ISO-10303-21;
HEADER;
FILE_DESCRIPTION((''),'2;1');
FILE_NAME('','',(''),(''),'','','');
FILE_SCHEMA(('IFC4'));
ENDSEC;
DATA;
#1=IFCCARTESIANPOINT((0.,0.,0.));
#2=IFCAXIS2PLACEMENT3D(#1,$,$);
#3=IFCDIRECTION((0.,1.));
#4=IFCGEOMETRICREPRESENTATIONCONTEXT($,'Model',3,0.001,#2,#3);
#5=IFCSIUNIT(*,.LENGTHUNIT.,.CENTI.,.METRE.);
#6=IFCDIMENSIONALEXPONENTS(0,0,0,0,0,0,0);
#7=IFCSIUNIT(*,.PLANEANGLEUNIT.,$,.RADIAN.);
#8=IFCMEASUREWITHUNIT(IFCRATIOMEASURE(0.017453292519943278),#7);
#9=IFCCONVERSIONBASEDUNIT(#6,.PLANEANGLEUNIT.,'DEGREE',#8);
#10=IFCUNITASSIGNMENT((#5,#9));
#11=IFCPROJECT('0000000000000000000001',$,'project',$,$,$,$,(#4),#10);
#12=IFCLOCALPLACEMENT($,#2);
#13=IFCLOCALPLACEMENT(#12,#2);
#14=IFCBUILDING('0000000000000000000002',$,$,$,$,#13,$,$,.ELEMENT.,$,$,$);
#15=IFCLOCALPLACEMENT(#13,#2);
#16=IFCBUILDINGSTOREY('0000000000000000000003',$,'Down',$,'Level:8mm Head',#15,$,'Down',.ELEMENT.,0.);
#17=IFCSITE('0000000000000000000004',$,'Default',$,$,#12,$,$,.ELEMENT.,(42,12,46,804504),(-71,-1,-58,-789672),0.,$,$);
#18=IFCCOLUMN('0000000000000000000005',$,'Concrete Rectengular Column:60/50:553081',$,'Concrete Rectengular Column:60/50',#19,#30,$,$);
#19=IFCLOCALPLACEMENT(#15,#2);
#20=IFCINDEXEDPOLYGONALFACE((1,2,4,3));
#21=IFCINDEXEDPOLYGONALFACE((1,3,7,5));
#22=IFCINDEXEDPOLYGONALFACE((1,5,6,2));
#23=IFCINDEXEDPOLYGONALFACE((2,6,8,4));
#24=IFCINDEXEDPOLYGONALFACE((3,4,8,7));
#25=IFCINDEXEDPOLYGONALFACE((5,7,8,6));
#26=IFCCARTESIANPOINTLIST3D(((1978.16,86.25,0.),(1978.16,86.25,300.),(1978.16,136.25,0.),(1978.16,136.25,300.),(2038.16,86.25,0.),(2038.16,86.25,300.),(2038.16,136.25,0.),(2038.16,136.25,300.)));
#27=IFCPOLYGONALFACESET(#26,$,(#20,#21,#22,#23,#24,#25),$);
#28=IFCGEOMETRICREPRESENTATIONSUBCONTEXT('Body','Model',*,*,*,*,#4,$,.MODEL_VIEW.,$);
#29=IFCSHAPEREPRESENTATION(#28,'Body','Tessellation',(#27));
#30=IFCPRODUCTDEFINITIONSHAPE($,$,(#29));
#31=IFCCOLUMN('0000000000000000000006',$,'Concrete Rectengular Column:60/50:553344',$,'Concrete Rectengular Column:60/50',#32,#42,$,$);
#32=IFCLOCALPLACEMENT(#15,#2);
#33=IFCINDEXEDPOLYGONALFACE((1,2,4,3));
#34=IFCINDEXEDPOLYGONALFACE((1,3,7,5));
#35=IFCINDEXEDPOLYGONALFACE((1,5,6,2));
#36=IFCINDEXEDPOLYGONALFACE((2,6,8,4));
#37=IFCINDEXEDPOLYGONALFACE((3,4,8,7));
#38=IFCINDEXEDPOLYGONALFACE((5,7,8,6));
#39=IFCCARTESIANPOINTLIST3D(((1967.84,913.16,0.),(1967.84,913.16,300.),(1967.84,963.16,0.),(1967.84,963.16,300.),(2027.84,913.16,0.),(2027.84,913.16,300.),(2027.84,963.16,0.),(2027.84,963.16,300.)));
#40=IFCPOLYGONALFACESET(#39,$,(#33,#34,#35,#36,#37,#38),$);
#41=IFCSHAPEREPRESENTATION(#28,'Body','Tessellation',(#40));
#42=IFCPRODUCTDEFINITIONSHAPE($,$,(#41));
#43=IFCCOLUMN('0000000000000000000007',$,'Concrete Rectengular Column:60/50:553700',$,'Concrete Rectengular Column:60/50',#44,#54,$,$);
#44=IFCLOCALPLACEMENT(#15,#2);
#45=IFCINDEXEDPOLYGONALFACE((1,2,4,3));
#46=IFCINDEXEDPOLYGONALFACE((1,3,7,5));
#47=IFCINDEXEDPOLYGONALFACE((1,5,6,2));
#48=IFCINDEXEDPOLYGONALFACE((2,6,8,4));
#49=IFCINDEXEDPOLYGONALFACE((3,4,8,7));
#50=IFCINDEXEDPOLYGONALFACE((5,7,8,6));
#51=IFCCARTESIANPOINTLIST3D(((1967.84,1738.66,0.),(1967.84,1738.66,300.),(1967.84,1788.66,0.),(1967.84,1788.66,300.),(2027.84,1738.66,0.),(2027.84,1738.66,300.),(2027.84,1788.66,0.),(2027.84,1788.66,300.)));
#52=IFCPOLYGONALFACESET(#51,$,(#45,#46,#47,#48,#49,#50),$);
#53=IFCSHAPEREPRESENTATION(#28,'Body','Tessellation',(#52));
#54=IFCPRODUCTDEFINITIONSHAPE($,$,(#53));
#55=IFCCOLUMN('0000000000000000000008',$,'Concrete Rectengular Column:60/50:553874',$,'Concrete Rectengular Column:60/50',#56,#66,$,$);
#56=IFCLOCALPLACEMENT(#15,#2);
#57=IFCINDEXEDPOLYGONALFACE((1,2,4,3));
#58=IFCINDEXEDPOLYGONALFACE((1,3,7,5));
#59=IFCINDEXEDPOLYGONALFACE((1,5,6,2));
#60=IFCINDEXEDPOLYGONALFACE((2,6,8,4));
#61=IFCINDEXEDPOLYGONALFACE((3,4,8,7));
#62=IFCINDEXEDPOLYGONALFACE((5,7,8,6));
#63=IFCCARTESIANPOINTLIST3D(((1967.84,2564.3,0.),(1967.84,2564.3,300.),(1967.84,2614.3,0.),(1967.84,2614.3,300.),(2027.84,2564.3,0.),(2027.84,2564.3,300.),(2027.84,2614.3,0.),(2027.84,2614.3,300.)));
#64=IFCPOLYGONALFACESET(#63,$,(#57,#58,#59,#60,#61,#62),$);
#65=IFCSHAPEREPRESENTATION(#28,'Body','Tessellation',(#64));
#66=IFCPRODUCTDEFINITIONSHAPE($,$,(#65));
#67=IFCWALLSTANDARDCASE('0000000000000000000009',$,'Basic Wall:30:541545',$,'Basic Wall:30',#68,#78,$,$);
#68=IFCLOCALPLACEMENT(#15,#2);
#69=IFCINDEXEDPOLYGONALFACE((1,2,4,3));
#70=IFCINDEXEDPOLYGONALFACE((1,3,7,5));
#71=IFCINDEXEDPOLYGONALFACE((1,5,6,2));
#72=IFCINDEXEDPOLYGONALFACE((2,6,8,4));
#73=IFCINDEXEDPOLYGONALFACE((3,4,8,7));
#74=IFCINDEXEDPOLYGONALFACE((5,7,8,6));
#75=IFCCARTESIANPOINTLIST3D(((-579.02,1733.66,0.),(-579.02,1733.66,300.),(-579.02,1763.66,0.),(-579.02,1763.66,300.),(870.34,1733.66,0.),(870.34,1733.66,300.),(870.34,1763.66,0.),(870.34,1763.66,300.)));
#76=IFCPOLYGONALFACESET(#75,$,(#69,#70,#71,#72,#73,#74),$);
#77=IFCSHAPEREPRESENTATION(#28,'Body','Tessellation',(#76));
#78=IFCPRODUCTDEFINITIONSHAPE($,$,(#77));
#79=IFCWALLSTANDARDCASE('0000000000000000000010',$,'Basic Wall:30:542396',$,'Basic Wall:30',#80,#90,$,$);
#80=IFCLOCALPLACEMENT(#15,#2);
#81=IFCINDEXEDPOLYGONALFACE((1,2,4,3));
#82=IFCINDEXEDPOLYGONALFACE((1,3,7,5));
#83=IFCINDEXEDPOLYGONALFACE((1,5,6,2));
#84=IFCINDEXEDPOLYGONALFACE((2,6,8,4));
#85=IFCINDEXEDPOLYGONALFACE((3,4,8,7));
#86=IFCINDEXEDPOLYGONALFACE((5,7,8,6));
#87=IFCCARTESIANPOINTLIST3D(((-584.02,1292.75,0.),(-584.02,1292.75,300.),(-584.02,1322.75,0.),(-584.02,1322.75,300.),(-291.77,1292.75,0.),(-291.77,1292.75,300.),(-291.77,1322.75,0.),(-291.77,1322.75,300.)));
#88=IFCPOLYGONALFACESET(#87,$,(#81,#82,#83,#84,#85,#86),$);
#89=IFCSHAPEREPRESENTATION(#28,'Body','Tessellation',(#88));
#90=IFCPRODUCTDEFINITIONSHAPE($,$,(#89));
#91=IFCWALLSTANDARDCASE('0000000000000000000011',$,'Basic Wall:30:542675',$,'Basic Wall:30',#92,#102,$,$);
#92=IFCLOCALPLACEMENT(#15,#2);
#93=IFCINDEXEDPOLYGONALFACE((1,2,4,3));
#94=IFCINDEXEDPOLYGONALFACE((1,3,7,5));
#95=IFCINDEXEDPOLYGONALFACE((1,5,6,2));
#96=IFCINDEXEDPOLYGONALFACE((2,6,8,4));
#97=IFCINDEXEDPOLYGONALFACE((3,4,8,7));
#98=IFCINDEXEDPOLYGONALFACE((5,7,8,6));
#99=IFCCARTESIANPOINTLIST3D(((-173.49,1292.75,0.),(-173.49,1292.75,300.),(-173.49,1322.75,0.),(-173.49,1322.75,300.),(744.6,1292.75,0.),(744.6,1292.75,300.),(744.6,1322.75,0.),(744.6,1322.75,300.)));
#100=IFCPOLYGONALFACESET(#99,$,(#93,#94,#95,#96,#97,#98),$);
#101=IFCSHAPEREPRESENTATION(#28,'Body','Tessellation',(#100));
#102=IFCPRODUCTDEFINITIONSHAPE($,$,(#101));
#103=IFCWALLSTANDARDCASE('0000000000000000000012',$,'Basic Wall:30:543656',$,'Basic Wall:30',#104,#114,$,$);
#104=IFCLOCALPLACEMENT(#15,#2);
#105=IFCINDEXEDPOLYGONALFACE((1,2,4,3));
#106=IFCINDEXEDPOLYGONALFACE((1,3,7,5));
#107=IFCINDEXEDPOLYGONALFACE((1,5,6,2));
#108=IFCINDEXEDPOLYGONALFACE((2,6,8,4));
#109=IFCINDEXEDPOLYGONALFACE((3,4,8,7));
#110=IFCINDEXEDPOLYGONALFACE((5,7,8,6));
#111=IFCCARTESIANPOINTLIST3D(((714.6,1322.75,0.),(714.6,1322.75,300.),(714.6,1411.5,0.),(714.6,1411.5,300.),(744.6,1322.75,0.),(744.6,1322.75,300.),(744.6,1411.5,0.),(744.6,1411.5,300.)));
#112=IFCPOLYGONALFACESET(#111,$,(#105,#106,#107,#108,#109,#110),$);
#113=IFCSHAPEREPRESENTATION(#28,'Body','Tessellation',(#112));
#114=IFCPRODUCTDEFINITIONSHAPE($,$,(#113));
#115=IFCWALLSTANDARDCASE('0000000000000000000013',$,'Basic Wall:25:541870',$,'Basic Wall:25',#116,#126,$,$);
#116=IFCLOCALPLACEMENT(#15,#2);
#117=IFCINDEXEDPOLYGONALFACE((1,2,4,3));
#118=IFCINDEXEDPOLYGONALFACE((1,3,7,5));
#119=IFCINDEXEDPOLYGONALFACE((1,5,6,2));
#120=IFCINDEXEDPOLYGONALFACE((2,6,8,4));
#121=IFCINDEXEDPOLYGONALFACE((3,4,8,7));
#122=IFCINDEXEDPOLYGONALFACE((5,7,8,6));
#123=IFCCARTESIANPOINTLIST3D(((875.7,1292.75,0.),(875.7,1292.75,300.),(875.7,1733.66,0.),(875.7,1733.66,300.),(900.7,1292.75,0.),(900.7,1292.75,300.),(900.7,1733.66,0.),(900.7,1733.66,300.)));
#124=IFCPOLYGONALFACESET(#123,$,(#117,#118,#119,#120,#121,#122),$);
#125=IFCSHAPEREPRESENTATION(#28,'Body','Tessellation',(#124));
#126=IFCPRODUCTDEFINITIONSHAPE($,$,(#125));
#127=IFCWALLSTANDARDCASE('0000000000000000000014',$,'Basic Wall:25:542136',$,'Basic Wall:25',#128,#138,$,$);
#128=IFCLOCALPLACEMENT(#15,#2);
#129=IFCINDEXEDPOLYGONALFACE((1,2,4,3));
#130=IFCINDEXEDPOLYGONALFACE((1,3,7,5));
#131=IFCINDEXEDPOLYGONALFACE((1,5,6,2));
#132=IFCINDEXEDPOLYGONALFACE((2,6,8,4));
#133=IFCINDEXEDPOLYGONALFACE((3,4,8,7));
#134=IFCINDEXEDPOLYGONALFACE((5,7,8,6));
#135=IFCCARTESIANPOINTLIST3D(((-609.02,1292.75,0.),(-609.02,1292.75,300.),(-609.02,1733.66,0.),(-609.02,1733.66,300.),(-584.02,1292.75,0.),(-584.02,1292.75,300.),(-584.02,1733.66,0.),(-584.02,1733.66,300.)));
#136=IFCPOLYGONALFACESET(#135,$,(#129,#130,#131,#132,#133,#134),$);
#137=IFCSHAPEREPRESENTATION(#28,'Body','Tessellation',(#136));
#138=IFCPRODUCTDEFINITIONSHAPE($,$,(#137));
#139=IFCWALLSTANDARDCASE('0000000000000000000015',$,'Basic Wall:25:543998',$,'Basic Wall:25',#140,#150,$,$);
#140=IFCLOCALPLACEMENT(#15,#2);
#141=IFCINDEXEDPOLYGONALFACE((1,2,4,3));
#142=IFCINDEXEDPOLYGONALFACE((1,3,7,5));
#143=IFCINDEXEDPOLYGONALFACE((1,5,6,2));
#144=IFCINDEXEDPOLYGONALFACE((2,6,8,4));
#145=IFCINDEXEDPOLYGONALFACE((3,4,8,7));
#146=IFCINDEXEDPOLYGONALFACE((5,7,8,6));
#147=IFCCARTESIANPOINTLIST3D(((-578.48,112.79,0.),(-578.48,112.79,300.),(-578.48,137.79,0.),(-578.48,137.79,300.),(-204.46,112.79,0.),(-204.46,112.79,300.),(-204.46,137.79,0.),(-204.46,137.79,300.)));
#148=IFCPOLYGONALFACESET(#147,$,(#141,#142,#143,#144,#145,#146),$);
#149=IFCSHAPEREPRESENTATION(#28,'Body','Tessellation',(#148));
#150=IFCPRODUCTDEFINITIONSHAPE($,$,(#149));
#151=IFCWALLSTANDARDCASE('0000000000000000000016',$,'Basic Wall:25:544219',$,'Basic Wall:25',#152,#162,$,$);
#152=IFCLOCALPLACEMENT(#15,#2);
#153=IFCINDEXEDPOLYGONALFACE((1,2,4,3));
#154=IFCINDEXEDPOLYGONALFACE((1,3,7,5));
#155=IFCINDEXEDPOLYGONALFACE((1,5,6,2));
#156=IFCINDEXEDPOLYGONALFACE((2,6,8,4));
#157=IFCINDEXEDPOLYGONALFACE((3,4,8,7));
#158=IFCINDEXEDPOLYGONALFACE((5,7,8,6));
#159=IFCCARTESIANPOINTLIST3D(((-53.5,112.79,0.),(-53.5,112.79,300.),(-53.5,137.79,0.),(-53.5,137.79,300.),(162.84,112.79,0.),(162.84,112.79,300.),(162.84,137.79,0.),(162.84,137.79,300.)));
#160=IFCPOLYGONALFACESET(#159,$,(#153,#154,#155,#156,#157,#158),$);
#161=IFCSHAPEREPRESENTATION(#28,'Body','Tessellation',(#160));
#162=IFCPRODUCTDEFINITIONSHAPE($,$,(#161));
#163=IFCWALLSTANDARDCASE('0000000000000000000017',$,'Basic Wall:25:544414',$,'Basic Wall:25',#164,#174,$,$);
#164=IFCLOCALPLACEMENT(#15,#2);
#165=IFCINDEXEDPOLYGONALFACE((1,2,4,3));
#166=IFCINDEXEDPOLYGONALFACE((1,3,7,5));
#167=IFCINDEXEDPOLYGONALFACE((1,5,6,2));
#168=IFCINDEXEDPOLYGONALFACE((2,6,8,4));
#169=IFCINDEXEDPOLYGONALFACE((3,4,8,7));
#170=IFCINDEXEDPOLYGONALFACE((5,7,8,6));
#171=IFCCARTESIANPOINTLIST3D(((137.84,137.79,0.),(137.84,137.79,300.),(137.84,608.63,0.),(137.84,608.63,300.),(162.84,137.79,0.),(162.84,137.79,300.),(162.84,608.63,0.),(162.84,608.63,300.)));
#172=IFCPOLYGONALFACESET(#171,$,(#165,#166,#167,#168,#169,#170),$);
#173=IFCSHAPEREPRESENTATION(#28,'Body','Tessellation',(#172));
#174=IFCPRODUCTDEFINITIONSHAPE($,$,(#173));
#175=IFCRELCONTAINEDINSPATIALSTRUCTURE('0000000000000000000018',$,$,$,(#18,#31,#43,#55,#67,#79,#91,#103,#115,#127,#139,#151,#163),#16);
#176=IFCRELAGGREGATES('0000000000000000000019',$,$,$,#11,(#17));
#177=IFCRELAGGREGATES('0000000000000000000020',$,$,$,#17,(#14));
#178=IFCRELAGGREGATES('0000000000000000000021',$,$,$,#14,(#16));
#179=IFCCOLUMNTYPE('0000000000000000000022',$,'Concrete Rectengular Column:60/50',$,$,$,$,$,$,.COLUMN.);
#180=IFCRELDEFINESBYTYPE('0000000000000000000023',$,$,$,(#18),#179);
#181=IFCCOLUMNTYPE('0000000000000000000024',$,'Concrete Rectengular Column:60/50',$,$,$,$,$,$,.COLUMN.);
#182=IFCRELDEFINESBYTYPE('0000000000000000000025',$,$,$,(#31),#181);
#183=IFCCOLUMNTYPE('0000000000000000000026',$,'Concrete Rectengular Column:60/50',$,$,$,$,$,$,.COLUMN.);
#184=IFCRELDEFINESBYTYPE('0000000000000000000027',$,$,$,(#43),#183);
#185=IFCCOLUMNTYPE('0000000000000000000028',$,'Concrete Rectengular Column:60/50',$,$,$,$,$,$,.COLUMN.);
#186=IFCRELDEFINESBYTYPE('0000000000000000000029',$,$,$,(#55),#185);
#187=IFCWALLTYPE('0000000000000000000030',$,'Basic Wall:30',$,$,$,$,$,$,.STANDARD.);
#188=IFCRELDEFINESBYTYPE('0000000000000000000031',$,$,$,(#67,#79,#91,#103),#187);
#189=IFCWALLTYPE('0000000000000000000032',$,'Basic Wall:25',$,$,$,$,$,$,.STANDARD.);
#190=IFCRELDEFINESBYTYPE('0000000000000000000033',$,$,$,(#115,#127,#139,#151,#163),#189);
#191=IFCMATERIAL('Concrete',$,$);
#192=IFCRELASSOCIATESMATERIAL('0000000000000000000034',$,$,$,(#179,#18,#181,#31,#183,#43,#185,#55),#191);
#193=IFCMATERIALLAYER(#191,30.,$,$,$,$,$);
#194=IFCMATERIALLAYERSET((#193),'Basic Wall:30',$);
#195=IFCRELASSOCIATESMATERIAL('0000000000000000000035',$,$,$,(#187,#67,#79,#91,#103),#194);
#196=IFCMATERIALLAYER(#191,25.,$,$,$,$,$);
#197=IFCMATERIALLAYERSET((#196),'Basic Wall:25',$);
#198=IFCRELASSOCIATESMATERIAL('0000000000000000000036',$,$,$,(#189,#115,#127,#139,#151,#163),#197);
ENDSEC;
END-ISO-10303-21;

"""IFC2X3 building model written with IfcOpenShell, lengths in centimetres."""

from ifc_helpers import new_model, entity, si_unit, converted_unit, direction, frame, frame_2d, origin, origin_2d_with_axis, place, context, subcontext, project, spatial, rectangle, extrude, source, transform, mapped, material, layer, layer_set, layer_usage, type_object, type_shapes, element, save


model = new_model("IFC2X3")

# Units and contexts
model_context = context("Model", 3, precision=0.001, world=origin(), true_north=direction((0.0, 1.0)))
body_context = subcontext(model_context, "Body", "Model", "MODEL_VIEW")
ifc_project = project(units=[si_unit("LENGTHUNIT", "METRE", prefix="CENTI"), converted_unit("PLANEANGLEUNIT", "DEGREE", entity("IfcRatioMeasure", 0.017453292519943278), si_unit("PLANEANGLEUNIT", "RADIAN"), dimensions=[0, 0, 0, 0, 0, 0, 0])], contexts=[model_context])

# Site, building, storey
site_placement = place(None, origin())
site = spatial("IfcSite", under=ifc_project, at=site_placement, Name="Default", CompositionType="ELEMENT", RefLatitude=(42, 12, 46, 804504), RefLongitude=(-71, -1, -58, -789672), RefElevation=0.0)
building_placement = place(site_placement, origin())
building = spatial("IfcBuilding", under=site, at=building_placement, CompositionType="ELEMENT")
storey_placement = place(building_placement, origin())
storey = spatial("IfcBuildingStorey", under=building, at=storey_placement, Name="Down", ObjectType="Level:8mm Head", LongName="Down", CompositionType="ELEMENT", Elevation=0.0)

# Columns
ifc_material = material(Name="Concrete")
column_type_1 = type_object("IfcColumnType", Name="Concrete Rectengular Column:60/50", PredefinedType="COLUMN", material=ifc_material)
shared_shape_1 = source(origin(), body_context, "Body", "SweptSolid", [
    extrude(rectangle(XDim=50.0, YDim=60.0, at=origin_2d_with_axis()), frame((2008.16, 111.25, 0.0), z_axis=(0.0, 0.0, 1.0), x_axis=(0.0, -1.0, 0.0)), (0.0, 0.0, 1.0), 300.0),
])
type_shapes(column_type_1, [shared_shape_1])
column_1_placement = place(storey_placement, origin())
element("IfcColumn", 1, at=column_1_placement, inside=storey, type_object=column_type_1, material=ifc_material, Name="Concrete Rectengular Column:60/50:553081", ObjectType="Concrete Rectengular Column:60/50", context=body_context, shape_type="MappedRepresentation", body=[
    mapped(shared_shape_1, transform((0.0, 0.0, 0.0), scale=1.0)),
])
column_type_2 = type_object("IfcColumnType", Name="Concrete Rectengular Column:60/50", PredefinedType="COLUMN", material=ifc_material)
shared_shape_2 = source(origin(), body_context, "Body", "SweptSolid", [
    extrude(rectangle(XDim=50.0, YDim=60.0, at=frame_2d((0.0, 0.0), x_axis=(1.0, 0.0))), frame((1997.84, 938.16, 0.0), z_axis=(0.0, 0.0, 1.0), x_axis=(0.0, -1.0, 0.0)), (0.0, 0.0, 1.0), 300.0),
])
type_shapes(column_type_2, [shared_shape_2])
column_2_placement = place(storey_placement, origin())
element("IfcColumn", 2, at=column_2_placement, inside=storey, type_object=column_type_2, material=ifc_material, Name="Concrete Rectengular Column:60/50:553344", ObjectType="Concrete Rectengular Column:60/50", context=body_context, shape_type="MappedRepresentation", body=[
    mapped(shared_shape_2, transform((0.0, 0.0, 0.0), scale=1.0)),
])
column_type_3 = type_object("IfcColumnType", Name="Concrete Rectengular Column:60/50", PredefinedType="COLUMN", material=ifc_material)
shared_shape_3 = source(origin(), body_context, "Body", "SweptSolid", [
    extrude(rectangle(XDim=50.0, YDim=60.0, at=origin_2d_with_axis()), frame((1997.84, 1763.66, 0.0), z_axis=(0.0, 0.0, 1.0), x_axis=(0.0, -1.0, 0.0)), (0.0, 0.0, 1.0), 300.0),
])
type_shapes(column_type_3, [shared_shape_3])
column_3_placement = place(storey_placement, origin())
element("IfcColumn", 3, at=column_3_placement, inside=storey, type_object=column_type_3, material=ifc_material, Name="Concrete Rectengular Column:60/50:553700", ObjectType="Concrete Rectengular Column:60/50", context=body_context, shape_type="MappedRepresentation", body=[
    mapped(shared_shape_3, transform((0.0, 0.0, 0.0), scale=1.0)),
])
column_type_4 = type_object("IfcColumnType", Name="Concrete Rectengular Column:60/50", PredefinedType="COLUMN", material=ifc_material)
shared_shape_4 = source(origin(), body_context, "Body", "SweptSolid", [
    extrude(rectangle(XDim=50.0, YDim=60.0, at=origin_2d_with_axis()), frame((1997.84, 2589.3, 0.0), z_axis=(0.0, 0.0, 1.0), x_axis=(0.0, -1.0, 0.0)), (0.0, 0.0, 1.0), 300.0),
])
type_shapes(column_type_4, [shared_shape_4])
column_4_placement = place(storey_placement, origin())
element("IfcColumn", 4, at=column_4_placement, inside=storey, type_object=column_type_4, material=ifc_material, Name="Concrete Rectengular Column:60/50:553874", ObjectType="Concrete Rectengular Column:60/50", context=body_context, shape_type="MappedRepresentation", body=[
    mapped(shared_shape_4, transform((0.0, 0.0, 0.0), scale=1.0)),
])

# Walls
ifc_layer_1 = layer(ifc_material, 30.0)
ifc_layer_set_1 = layer_set([ifc_layer_1], Name="Basic Wall:30")
ifc_layer_usage_1 = layer_usage(ifc_layer_set_1, "AXIS2", "POSITIVE", -15.0)
wall_type_1 = type_object("IfcWallType", Name="Basic Wall:30", PredefinedType="STANDARD", material=ifc_layer_set_1)
wall_1_placement = place(storey_placement, frame((-579.02, 1748.66, 0.0)))
element("IfcWallStandardCase", 5, at=wall_1_placement, inside=storey, type_object=wall_type_1, material=ifc_layer_usage_1, Name="Basic Wall:30:541545", ObjectType="Basic Wall:30", context=body_context, shape_type="SweptSolid", body=[
    extrude(rectangle(XDim=1449.35, YDim=30.0, at=frame_2d((724.68, 0.0), x_axis=(-1.0, 0.0))), origin(), (0.0, 0.0, 1.0), 300.0),
])
ifc_layer_usage_2 = layer_usage(ifc_layer_set_1, "AXIS2", "POSITIVE", -15.0)
wall_2_placement = place(storey_placement, frame((-584.02, 1307.75, 0.0)))
element("IfcWallStandardCase", 6, at=wall_2_placement, inside=storey, type_object=wall_type_1, material=ifc_layer_usage_2, Name="Basic Wall:30:542396", ObjectType="Basic Wall:30", context=body_context, shape_type="SweptSolid", body=[
    extrude(rectangle(XDim=292.24, YDim=30.0, at=frame_2d((146.12, 0.0), x_axis=(-1.0, 0.0))), origin(), (0.0, 0.0, 1.0), 300.0),
])
ifc_layer_usage_3 = layer_usage(ifc_layer_set_1, "AXIS2", "POSITIVE", -15.0)
wall_3_placement = place(storey_placement, frame((-173.49, 1307.75, 0.0)))
element("IfcWallStandardCase", 7, at=wall_3_placement, inside=storey, type_object=wall_type_1, material=ifc_layer_usage_3, Name="Basic Wall:30:542675", ObjectType="Basic Wall:30", context=body_context, shape_type="SweptSolid", body=[
    extrude(rectangle(XDim=918.08, YDim=30.0, at=frame_2d((459.04, 0.0), x_axis=(-1.0, 0.0))), origin(), (0.0, 0.0, 1.0), 300.0),
])
ifc_layer_usage_4 = layer_usage(ifc_layer_set_1, "AXIS2", "POSITIVE", -15.0)
wall_4_placement = place(storey_placement, frame((729.6, 1322.75, 0.0), z_axis=(0.0, 0.0, 1.0), x_axis=(0.0, 1.0, 0.0)))
element("IfcWallStandardCase", 8, at=wall_4_placement, inside=storey, type_object=wall_type_1, material=ifc_layer_usage_4, Name="Basic Wall:30:543656", ObjectType="Basic Wall:30", context=body_context, shape_type="SweptSolid", body=[
    extrude(rectangle(XDim=88.75, YDim=30.0, at=frame_2d((44.37, 0.0), x_axis=(-1.0, 0.0))), origin(), (0.0, 0.0, 1.0), 300.0),
])
ifc_layer_2 = layer(ifc_material, 25.0)
ifc_layer_set_2 = layer_set([ifc_layer_2], Name="Basic Wall:25")
ifc_layer_usage_5 = layer_usage(ifc_layer_set_2, "AXIS2", "NEGATIVE", 12.5)
wall_type_2 = type_object("IfcWallType", Name="Basic Wall:25", PredefinedType="STANDARD", material=ifc_layer_set_2)
wall_5_placement = place(storey_placement, frame((888.2, 1733.66, 0.0), z_axis=(0.0, 0.0, 1.0), x_axis=(0.0, -1.0, 0.0)))
element("IfcWallStandardCase", 9, at=wall_5_placement, inside=storey, type_object=wall_type_2, material=ifc_layer_usage_5, Name="Basic Wall:25:541870", ObjectType="Basic Wall:25", context=body_context, shape_type="SweptSolid", body=[
    extrude(rectangle(XDim=440.91, YDim=25.0, at=frame_2d((220.46, 0.0), x_axis=(-1.0, 0.0))), origin(), (0.0, 0.0, 1.0), 300.0),
])
ifc_layer_usage_6 = layer_usage(ifc_layer_set_2, "AXIS2", "NEGATIVE", 12.5)
wall_6_placement = place(storey_placement, frame((-596.52, 1733.66, 0.0), z_axis=(0.0, 0.0, 1.0), x_axis=(0.0, -1.0, 0.0)))
element("IfcWallStandardCase", 10, at=wall_6_placement, inside=storey, type_object=wall_type_2, material=ifc_layer_usage_6, Name="Basic Wall:25:542136", ObjectType="Basic Wall:25", context=body_context, shape_type="SweptSolid", body=[
    extrude(rectangle(XDim=440.91, YDim=25.0, at=frame_2d((220.46, 0.0), x_axis=(-1.0, 0.0))), origin(), (0.0, 0.0, 1.0), 300.0),
])
ifc_layer_usage_7 = layer_usage(ifc_layer_set_2, "AXIS2", "NEGATIVE", 12.5)
wall_7_placement = place(storey_placement, frame((-578.48, 125.29, 0.0)))
element("IfcWallStandardCase", 11, at=wall_7_placement, inside=storey, type_object=wall_type_2, material=ifc_layer_usage_7, Name="Basic Wall:25:543998", ObjectType="Basic Wall:25", context=body_context, shape_type="SweptSolid", body=[
    extrude(rectangle(XDim=374.02, YDim=25.0, at=frame_2d((187.01, 0.0), x_axis=(-1.0, 0.0))), origin(), (0.0, 0.0, 1.0), 300.0),
])
ifc_layer_usage_8 = layer_usage(ifc_layer_set_2, "AXIS2", "NEGATIVE", 12.5)
wall_8_placement = place(storey_placement, frame((-53.5, 125.29, 0.0)))
element("IfcWallStandardCase", 12, at=wall_8_placement, inside=storey, type_object=wall_type_2, material=ifc_layer_usage_8, Name="Basic Wall:25:544219", ObjectType="Basic Wall:25", context=body_context, shape_type="SweptSolid", body=[
    extrude(rectangle(XDim=216.33, YDim=25.0, at=frame_2d((108.17, 0.0), x_axis=(-1.0, 0.0))), origin(), (0.0, 0.0, 1.0), 300.0),
])
ifc_layer_usage_9 = layer_usage(ifc_layer_set_2, "AXIS2", "POSITIVE", -12.5)
wall_9_placement = place(storey_placement, frame((150.34, 137.79, 0.0), z_axis=(0.0, 0.0, 1.0), x_axis=(0.0, 1.0, 0.0)))
element("IfcWallStandardCase", 13, at=wall_9_placement, inside=storey, type_object=wall_type_2, material=ifc_layer_usage_9, Name="Basic Wall:25:544414", ObjectType="Basic Wall:25", context=body_context, shape_type="SweptSolid", body=[
    extrude(rectangle(XDim=470.84, YDim=25.0, at=frame_2d((235.42, 0.0), x_axis=(-1.0, 0.0))), origin(), (0.0, 0.0, 1.0), 300.0),
])

save(model, "model.ifc")
